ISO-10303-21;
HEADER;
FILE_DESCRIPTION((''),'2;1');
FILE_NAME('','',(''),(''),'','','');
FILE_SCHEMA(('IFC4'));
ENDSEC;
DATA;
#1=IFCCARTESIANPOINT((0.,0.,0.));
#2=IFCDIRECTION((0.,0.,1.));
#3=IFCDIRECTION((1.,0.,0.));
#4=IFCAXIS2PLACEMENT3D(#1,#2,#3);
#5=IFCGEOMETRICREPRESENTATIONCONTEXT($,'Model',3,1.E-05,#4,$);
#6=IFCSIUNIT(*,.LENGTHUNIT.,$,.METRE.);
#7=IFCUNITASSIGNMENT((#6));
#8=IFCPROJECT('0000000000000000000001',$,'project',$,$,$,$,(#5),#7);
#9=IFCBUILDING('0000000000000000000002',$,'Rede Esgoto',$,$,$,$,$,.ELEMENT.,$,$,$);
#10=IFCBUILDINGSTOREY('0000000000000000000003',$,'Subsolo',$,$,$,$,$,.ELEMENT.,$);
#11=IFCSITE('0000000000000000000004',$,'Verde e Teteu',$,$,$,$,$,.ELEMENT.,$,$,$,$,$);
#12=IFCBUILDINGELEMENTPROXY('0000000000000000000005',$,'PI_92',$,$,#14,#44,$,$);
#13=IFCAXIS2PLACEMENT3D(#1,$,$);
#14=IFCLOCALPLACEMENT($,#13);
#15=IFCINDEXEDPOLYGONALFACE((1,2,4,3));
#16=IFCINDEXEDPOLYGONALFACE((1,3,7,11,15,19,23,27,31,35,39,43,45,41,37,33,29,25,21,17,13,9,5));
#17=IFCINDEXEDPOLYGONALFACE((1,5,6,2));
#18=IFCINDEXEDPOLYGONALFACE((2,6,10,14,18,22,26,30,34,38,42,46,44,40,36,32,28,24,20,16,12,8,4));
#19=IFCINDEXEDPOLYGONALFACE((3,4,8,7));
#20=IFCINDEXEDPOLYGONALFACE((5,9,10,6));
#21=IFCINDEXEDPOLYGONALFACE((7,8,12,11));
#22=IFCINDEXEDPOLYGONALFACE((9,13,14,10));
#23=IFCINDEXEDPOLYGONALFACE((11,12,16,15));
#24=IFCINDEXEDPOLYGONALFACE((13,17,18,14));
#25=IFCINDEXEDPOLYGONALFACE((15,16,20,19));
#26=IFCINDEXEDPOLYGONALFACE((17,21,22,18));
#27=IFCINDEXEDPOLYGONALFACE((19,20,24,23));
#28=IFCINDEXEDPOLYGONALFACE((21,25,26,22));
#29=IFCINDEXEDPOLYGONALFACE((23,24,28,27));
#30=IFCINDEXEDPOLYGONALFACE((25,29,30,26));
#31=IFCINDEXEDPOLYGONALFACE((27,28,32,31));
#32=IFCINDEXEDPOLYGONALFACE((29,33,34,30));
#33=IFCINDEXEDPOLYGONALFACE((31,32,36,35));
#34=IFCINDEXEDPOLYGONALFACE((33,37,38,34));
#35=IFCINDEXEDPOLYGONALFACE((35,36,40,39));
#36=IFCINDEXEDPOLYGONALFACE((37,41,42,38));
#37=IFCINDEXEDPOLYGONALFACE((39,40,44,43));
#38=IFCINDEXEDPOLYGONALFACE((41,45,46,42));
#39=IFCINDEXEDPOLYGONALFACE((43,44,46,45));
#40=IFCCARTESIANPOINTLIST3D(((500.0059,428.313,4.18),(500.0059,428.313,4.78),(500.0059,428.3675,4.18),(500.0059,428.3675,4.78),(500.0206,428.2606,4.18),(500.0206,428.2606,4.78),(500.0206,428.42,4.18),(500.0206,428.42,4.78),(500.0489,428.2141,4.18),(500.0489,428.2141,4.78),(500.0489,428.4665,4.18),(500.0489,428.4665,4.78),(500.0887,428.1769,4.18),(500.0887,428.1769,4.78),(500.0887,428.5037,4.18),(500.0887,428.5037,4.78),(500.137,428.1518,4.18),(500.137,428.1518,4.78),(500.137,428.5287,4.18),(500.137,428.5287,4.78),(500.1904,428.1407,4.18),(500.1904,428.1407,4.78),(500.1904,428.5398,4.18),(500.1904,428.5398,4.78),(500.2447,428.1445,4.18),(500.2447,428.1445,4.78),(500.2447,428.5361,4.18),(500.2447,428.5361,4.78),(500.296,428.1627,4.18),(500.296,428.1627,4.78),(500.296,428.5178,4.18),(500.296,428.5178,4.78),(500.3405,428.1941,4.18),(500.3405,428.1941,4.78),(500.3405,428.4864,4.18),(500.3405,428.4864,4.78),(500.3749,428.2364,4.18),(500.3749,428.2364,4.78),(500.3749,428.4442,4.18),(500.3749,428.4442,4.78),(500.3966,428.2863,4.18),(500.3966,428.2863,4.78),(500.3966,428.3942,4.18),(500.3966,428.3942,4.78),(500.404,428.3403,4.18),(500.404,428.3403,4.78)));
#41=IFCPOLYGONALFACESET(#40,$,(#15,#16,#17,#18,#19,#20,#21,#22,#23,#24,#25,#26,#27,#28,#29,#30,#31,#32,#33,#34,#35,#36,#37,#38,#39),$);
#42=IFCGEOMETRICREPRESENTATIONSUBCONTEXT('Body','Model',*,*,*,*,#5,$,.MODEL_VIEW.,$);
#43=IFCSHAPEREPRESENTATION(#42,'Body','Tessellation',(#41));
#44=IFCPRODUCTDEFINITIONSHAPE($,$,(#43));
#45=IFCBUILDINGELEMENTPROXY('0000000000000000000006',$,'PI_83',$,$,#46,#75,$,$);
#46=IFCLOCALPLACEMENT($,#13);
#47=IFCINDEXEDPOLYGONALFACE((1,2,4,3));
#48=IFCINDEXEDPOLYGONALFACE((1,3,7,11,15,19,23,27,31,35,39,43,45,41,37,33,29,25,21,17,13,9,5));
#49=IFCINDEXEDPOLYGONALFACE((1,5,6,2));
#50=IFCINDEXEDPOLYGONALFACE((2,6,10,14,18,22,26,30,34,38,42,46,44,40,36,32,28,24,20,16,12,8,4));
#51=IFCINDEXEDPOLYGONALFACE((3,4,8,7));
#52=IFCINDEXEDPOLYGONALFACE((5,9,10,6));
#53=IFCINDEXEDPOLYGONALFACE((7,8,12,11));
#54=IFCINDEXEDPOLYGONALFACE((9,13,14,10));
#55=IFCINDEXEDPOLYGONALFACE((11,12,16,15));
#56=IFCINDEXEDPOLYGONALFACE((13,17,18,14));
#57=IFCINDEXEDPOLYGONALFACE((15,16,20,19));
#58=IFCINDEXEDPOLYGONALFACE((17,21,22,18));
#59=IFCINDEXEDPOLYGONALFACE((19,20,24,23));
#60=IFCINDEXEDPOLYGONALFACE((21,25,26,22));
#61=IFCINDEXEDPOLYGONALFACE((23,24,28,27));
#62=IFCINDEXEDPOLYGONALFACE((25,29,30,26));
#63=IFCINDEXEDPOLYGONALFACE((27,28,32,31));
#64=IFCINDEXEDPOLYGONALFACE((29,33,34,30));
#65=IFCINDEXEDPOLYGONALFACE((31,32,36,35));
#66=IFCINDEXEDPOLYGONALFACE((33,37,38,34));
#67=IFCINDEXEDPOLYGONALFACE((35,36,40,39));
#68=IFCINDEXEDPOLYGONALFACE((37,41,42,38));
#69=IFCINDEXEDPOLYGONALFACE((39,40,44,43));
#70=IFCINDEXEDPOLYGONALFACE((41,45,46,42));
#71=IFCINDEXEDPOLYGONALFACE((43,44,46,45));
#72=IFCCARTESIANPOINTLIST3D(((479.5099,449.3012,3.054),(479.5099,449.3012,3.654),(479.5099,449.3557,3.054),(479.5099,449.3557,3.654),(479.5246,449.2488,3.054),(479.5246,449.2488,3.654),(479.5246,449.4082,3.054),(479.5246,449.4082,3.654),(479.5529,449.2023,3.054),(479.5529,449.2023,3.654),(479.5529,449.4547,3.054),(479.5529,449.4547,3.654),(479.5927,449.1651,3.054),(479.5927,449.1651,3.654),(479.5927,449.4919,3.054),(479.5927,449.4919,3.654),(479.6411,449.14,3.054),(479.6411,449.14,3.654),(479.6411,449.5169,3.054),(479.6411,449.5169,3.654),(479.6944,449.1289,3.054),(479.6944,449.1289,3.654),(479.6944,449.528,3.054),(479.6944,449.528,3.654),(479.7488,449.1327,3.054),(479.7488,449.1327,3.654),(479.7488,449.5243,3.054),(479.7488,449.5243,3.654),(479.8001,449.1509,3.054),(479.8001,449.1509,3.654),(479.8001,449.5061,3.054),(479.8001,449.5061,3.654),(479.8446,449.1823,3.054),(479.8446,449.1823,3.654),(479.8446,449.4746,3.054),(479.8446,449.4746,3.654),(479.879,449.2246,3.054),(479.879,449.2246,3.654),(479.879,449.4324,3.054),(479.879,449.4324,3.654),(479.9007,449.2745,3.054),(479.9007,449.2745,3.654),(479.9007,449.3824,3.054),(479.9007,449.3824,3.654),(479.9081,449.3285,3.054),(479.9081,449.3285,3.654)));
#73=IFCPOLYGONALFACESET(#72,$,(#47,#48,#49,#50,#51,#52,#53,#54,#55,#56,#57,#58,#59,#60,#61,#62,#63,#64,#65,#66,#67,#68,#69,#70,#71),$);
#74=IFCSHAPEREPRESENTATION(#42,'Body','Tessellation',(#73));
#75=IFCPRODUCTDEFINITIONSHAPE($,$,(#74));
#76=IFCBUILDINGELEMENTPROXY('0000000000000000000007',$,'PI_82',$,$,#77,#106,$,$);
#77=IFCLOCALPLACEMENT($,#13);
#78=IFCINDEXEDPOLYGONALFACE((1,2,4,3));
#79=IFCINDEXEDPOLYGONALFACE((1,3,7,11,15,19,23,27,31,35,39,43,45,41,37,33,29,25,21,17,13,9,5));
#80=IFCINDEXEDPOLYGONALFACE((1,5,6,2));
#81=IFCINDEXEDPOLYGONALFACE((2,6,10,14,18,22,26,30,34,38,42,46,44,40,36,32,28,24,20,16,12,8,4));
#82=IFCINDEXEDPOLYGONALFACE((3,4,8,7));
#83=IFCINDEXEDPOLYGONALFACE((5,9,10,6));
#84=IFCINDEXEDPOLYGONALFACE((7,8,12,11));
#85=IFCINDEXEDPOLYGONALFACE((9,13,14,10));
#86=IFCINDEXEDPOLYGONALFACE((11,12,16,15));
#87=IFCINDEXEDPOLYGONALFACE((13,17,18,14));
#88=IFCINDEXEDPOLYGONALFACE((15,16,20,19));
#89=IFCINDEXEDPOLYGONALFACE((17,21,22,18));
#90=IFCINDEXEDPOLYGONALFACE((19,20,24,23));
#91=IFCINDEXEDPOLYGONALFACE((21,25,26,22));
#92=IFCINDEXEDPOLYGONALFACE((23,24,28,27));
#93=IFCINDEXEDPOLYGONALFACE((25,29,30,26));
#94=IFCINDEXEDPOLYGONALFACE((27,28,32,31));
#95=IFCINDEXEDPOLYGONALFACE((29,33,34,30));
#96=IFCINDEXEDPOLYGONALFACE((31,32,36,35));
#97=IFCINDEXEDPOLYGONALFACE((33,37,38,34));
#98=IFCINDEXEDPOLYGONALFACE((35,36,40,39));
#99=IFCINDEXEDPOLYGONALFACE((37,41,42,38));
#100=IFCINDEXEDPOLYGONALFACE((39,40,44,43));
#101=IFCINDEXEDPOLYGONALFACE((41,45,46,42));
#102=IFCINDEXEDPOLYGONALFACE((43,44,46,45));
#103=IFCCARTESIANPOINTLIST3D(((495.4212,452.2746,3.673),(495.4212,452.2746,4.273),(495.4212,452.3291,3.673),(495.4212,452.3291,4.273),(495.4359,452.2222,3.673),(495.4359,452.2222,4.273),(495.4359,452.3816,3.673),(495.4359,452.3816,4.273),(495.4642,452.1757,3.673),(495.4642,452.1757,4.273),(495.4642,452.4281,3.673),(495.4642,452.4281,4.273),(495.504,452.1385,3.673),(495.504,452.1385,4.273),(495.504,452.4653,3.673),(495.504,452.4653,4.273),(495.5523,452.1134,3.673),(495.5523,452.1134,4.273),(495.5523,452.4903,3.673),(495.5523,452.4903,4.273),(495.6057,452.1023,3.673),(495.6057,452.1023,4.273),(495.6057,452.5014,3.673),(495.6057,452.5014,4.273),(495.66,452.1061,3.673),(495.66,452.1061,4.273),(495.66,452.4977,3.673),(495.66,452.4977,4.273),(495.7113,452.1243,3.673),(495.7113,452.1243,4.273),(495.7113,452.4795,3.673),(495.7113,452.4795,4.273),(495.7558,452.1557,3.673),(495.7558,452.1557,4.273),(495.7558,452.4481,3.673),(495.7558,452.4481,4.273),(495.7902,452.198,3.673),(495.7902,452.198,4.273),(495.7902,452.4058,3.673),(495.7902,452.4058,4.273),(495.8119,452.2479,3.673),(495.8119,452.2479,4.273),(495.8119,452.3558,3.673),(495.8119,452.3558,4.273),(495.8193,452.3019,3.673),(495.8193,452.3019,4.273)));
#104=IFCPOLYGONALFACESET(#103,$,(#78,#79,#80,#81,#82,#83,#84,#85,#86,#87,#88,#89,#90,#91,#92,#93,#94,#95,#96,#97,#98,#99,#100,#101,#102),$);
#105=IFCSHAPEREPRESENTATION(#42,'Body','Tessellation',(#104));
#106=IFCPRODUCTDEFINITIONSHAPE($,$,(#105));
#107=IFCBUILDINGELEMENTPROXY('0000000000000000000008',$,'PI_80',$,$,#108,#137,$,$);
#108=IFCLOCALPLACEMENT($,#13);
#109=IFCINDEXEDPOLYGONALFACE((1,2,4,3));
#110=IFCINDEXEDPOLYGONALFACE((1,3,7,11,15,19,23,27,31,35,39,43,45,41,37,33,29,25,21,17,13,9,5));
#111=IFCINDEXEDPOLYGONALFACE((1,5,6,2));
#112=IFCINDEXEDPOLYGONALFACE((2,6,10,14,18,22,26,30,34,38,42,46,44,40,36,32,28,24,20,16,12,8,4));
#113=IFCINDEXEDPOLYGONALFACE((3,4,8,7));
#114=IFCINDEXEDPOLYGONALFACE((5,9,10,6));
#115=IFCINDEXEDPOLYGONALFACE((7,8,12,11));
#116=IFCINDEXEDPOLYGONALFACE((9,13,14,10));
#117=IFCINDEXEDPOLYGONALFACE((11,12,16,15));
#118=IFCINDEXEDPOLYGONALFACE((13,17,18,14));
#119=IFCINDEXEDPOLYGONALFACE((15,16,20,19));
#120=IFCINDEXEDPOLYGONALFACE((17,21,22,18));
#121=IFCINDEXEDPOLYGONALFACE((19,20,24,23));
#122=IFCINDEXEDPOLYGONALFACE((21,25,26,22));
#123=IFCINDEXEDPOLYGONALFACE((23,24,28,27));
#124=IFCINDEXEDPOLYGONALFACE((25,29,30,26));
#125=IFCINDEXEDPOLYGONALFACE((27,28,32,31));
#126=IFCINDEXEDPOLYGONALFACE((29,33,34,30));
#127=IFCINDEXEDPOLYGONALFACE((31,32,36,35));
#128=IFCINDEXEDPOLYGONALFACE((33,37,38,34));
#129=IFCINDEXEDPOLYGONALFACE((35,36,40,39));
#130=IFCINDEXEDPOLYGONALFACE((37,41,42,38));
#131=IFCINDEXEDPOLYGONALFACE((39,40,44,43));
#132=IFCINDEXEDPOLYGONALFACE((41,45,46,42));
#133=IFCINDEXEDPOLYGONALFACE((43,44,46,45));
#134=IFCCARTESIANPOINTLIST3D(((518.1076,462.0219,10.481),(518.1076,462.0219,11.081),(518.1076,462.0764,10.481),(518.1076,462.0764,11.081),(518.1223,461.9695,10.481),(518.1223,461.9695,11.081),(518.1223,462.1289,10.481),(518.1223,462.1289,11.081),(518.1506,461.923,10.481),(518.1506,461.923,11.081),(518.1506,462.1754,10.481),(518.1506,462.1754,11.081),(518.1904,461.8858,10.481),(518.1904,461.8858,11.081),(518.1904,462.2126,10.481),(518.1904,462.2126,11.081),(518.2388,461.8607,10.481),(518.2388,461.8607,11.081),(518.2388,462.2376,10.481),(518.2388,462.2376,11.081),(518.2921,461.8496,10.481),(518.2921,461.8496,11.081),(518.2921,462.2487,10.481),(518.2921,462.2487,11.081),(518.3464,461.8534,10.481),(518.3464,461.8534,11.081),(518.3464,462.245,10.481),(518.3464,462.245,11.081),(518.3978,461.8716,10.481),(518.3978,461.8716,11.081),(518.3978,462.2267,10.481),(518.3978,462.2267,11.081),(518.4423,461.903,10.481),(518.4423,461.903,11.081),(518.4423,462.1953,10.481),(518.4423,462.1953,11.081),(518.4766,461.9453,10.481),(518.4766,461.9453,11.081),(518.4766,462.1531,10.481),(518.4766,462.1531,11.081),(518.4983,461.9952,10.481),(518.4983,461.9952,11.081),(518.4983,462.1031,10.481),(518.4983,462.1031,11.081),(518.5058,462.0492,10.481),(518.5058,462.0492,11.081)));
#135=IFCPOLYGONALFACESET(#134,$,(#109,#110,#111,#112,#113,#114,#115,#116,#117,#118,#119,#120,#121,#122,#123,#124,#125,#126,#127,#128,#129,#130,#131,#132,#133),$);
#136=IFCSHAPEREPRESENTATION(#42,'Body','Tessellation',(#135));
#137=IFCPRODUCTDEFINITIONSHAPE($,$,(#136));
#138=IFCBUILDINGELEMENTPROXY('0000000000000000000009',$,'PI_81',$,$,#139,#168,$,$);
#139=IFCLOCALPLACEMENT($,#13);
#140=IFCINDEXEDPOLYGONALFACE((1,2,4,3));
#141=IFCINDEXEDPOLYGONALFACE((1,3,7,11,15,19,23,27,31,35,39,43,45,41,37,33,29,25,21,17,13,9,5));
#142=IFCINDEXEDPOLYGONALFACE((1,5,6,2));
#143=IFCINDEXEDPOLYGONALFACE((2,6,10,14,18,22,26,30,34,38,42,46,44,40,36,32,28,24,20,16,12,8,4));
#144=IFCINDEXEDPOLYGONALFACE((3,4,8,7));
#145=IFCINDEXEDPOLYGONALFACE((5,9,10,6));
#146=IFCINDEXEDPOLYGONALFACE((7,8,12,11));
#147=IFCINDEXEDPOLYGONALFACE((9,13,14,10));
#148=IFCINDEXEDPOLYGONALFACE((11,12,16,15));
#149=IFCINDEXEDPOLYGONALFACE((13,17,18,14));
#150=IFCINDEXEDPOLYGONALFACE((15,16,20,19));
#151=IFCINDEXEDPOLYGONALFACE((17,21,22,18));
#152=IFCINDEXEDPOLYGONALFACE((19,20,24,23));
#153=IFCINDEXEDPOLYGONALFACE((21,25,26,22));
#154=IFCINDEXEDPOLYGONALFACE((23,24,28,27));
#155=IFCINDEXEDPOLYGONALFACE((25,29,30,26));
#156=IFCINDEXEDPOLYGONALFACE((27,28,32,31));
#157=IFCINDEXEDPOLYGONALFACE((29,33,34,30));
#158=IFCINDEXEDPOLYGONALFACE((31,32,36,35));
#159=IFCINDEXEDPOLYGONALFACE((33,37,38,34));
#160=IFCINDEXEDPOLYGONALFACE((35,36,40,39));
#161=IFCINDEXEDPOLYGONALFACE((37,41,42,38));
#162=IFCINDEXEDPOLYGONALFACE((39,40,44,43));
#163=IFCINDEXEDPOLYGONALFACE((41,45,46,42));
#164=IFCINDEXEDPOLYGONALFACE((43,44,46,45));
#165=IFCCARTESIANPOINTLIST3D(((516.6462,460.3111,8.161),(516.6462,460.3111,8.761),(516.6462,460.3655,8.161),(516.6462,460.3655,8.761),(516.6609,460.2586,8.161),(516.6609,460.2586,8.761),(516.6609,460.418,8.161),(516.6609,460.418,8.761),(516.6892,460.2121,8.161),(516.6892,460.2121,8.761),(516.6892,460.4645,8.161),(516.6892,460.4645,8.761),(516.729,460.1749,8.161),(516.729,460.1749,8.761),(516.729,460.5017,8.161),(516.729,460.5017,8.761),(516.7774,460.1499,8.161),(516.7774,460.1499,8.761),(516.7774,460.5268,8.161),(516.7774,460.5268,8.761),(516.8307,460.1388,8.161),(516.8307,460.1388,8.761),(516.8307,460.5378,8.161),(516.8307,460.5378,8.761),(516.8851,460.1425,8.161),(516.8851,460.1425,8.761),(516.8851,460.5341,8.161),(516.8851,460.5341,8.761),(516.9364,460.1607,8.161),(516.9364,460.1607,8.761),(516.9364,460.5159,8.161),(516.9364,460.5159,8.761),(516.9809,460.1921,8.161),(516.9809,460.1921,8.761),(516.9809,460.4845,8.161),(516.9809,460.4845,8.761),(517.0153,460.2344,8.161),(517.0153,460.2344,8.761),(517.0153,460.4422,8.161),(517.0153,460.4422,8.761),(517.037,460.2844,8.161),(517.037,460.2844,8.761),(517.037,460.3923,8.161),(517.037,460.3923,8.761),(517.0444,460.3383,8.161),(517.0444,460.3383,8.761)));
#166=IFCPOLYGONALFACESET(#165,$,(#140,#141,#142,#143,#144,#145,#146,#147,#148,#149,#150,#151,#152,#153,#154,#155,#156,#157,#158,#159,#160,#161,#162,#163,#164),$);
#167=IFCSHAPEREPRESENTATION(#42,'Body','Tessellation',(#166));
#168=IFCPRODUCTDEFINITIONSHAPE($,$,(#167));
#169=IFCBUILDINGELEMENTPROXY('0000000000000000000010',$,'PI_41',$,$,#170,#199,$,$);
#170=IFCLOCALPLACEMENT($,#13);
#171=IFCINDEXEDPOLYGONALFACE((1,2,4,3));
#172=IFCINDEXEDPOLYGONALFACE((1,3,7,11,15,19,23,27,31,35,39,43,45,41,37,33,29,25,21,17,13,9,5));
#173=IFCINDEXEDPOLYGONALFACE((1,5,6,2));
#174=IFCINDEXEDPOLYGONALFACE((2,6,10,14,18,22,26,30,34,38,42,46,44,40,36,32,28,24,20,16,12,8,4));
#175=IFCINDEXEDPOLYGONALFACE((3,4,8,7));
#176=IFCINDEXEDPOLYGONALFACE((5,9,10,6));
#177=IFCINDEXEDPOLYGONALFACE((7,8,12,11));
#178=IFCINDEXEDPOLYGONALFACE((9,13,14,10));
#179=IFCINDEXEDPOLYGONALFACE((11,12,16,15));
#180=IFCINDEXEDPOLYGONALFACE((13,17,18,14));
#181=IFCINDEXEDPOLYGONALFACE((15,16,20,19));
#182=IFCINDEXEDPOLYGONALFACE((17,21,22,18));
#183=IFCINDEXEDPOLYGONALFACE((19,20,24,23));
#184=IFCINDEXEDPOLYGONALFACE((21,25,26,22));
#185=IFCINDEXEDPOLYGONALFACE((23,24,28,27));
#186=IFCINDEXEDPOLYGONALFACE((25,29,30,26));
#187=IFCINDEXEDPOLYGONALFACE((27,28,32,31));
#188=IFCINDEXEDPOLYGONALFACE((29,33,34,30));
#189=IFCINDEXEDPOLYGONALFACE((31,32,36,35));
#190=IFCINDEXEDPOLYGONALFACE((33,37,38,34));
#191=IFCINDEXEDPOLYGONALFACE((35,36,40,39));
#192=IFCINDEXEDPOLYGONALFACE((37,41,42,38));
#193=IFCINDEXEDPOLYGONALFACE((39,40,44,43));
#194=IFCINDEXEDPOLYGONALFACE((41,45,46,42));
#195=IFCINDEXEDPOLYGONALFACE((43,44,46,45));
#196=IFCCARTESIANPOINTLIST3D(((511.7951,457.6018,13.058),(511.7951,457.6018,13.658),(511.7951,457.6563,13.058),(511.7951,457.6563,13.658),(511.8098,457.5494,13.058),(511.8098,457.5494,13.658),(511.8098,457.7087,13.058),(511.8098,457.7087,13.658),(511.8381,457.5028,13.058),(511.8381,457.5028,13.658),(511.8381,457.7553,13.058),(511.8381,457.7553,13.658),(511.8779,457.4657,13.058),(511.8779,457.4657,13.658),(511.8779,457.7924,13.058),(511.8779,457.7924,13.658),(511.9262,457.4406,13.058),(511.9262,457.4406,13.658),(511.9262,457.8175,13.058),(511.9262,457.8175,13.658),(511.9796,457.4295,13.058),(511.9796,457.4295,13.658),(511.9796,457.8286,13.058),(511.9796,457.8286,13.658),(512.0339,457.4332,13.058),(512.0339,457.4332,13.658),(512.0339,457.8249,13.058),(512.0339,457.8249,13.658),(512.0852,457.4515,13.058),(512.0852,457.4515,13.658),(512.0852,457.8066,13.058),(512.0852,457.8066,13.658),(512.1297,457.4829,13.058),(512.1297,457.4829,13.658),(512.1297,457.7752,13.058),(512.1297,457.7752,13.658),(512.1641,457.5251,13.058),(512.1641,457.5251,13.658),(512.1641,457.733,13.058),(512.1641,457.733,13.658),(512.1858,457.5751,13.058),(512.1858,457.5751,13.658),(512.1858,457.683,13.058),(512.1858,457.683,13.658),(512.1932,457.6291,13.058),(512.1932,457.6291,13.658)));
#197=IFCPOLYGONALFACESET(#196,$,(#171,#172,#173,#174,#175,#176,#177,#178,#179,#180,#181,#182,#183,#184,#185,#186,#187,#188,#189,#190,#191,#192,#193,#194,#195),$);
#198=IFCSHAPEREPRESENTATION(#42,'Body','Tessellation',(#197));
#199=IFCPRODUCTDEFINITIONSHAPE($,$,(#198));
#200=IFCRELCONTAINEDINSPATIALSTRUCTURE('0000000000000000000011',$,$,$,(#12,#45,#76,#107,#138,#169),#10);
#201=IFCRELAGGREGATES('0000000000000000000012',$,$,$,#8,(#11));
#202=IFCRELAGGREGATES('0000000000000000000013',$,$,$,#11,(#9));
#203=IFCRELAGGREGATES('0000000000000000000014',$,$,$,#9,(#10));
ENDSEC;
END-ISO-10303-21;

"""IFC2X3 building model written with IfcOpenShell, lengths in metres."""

from ifc_helpers import new_model, si_unit, frame, origin_with_axes, origin_2d, place, context, subcontext, project, spatial, circle, extrude, element, save


model = new_model("IFC2X3")

# Units and contexts
model_context = context("Model", 3, precision=1e-05, world=origin_with_axes())
body_context = subcontext(model_context, "Body", "Model", "MODEL_VIEW")
ifc_project = project(units=[si_unit("LENGTHUNIT", "METRE")], contexts=[model_context])

# Site, building, storey
site = spatial("IfcSite", under=ifc_project, Name="Verde e Teteu", CompositionType="ELEMENT")
building = spatial("IfcBuilding", under=site, Name="Rede Esgoto", CompositionType="ELEMENT")
storey = spatial("IfcBuildingStorey", under=building, Name="Subsolo", CompositionType="ELEMENT")

# Building element proxies
proxy_1_placement = place(None, frame((500.204, 428.3403, 4.18), z_axis=(0.0, 0.0, 1.0), x_axis=(1.0, 0.0, 0.0)))
element("IfcBuildingElementProxy", 1, at=proxy_1_placement, inside=storey, Name="PI_92", context=body_context, shape_type="SweptSolid", body=[
    extrude(circle(Radius=0.2, at=origin_2d()), origin_with_axes(), (0.0, 0.0, 1.0), 0.6),
])
for number, where, z_axis, x_axis, name in (
    (2, (479.7081, 449.3285, 3.054), (0.0, 0.0, 1.0), (1.0, 0.0, 0.0), "PI_83"),
    (3, (495.6193, 452.3019, 3.673), (0.0, 0.0, 1.0), (1.0, 0.0, 0.0), "PI_82"),
    (4, (518.3058, 462.0492, 10.481), (0.0, 0.0, 1.0), (1.0, 0.0, 0.0), "PI_80"),
    (5, (516.8444, 460.3383, 8.161), (0.0, 0.0, 1.0), (1.0, 0.0, 0.0), "PI_81"),
    (6, (511.9932, 457.6291, 13.058), (0.0, 0.0, 1.0), (1.0, 0.0, 0.0), "PI_41"),
):
    element("IfcBuildingElementProxy", number, at=place(None, frame(where, z_axis=z_axis, x_axis=x_axis)), inside=storey, Name=name, context=body_context, shape_type="SweptSolid", body=[
        extrude(circle(Radius=0.2, at=origin_2d()), origin_with_axes(), (0.0, 0.0, 1.0), 0.6),
    ])

save(model, "model.ifc")
